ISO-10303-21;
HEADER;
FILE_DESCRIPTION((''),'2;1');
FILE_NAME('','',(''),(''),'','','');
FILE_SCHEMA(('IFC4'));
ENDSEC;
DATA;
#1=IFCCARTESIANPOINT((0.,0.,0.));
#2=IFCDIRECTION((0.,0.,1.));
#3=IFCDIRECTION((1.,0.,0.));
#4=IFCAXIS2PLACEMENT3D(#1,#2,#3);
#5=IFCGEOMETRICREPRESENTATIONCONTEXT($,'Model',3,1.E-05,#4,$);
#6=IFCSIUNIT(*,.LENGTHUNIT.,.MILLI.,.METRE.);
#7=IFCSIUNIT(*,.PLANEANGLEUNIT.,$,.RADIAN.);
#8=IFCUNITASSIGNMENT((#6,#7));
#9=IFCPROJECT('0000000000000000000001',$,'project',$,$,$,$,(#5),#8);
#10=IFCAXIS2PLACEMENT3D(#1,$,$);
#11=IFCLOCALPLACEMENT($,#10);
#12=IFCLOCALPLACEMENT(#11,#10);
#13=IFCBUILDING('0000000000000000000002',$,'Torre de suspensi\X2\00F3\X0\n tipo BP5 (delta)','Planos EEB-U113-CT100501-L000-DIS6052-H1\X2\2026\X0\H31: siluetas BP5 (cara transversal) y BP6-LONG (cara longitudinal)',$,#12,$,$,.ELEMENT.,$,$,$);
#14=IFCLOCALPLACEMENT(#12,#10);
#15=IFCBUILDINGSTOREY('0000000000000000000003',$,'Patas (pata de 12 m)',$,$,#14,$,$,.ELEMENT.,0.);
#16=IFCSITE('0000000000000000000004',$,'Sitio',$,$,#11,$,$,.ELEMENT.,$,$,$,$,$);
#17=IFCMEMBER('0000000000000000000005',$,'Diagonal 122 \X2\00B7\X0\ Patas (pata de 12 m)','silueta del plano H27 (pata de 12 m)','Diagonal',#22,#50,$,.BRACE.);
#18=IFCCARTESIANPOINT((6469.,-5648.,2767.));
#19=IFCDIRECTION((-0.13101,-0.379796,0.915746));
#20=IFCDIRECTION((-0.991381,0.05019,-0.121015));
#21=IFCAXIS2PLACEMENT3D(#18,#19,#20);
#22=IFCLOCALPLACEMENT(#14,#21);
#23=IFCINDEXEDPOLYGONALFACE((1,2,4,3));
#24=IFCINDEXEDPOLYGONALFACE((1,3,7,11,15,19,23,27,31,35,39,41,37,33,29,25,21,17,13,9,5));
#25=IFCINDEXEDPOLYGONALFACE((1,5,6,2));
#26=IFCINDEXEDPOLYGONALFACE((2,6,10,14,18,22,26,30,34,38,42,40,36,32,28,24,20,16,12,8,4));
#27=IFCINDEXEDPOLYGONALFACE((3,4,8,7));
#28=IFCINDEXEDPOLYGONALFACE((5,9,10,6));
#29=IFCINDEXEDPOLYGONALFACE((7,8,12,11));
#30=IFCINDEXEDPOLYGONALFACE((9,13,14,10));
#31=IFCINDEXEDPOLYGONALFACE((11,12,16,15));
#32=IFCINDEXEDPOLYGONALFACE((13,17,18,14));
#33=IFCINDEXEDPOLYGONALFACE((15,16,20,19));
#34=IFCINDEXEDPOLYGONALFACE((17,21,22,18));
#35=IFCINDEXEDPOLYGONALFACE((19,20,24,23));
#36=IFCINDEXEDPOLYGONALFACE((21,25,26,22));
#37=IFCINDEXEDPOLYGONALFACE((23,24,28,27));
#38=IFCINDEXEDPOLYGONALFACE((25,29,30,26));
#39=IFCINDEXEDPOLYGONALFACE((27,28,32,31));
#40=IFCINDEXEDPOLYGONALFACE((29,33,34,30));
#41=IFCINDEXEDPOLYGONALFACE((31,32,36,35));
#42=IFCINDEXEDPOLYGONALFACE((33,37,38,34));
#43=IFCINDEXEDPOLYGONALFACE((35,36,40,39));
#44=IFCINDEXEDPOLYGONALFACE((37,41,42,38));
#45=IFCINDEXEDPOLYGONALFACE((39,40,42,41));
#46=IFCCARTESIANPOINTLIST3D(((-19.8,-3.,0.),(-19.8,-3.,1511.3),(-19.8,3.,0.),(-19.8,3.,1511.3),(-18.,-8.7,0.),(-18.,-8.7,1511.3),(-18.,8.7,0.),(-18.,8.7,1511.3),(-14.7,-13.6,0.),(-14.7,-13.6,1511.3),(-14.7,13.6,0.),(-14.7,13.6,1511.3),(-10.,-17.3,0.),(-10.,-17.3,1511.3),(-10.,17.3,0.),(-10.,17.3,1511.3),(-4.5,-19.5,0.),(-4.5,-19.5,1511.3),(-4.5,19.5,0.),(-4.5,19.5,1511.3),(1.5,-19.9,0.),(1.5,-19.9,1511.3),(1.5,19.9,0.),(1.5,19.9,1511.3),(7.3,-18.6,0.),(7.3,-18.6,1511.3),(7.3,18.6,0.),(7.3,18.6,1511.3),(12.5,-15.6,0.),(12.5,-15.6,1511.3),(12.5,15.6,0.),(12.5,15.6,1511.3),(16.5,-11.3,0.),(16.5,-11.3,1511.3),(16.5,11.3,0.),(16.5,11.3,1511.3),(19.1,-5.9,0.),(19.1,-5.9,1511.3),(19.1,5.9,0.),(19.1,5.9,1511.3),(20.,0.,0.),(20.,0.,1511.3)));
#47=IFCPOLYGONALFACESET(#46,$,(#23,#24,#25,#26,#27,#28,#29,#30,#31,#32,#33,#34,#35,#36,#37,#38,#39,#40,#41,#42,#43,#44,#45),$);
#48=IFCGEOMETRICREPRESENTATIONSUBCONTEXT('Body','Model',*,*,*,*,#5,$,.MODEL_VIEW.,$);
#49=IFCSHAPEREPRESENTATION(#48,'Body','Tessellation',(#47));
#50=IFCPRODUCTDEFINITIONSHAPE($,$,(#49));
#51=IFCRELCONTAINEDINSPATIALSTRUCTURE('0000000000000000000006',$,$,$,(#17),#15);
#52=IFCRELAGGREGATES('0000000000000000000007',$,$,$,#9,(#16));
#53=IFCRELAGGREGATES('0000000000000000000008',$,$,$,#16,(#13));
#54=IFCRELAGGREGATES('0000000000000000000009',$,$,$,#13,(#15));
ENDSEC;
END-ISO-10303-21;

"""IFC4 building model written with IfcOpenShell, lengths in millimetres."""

from ifc_helpers import new_model, si_unit, frame, origin, origin_with_axes, place, context, subcontext, project, spatial, circle, extrude, element, save


model = new_model("IFC4")

# Units and contexts
model_context = context("Model", 3, precision=1e-05, world=origin_with_axes())
body_context = subcontext(model_context, "Body", "Model", "MODEL_VIEW")
ifc_project = project(units=[si_unit("LENGTHUNIT", "METRE", prefix="MILLI"), si_unit("PLANEANGLEUNIT", "RADIAN")], contexts=[model_context])

# Site, building, storey
site_placement = place(None, origin())
site = spatial("IfcSite", under=ifc_project, at=site_placement, Name="Sitio", CompositionType="ELEMENT")
building_placement = place(site_placement, origin())
building = spatial("IfcBuilding", under=site, at=building_placement, Name="Torre de suspensión tipo BP5 (delta)", Description="Planos EEB-U113-CT100501-L000-DIS6052-H1…H31: siluetas BP5 (cara transversal) y BP6-LONG (cara longitudinal)", CompositionType="ELEMENT")
storey_placement = place(building_placement, origin())
storey = spatial("IfcBuildingStorey", under=building, at=storey_placement, Name="Patas (pata de 12 m)", CompositionType="ELEMENT", Elevation=0.0)

# Member
member_1_placement = place(storey_placement, frame((6469.0, -5648.0, 2767.0), z_axis=(-0.13101, -0.379796, 0.915746), x_axis=(-0.991381, 0.05019, -0.121015)))
element("IfcMember", 1, at=member_1_placement, inside=storey, Name="Diagonal 122 · Patas (pata de 12 m)", Description="silueta del plano H27 (pata de 12 m)", ObjectType="Diagonal", PredefinedType="BRACE", context=body_context, shape_type="SweptSolid", body=[
    extrude(circle(Radius=20.0), None, (0.0, 0.0, 1.0), 1511.3),
])

save(model, "model.ifc")
